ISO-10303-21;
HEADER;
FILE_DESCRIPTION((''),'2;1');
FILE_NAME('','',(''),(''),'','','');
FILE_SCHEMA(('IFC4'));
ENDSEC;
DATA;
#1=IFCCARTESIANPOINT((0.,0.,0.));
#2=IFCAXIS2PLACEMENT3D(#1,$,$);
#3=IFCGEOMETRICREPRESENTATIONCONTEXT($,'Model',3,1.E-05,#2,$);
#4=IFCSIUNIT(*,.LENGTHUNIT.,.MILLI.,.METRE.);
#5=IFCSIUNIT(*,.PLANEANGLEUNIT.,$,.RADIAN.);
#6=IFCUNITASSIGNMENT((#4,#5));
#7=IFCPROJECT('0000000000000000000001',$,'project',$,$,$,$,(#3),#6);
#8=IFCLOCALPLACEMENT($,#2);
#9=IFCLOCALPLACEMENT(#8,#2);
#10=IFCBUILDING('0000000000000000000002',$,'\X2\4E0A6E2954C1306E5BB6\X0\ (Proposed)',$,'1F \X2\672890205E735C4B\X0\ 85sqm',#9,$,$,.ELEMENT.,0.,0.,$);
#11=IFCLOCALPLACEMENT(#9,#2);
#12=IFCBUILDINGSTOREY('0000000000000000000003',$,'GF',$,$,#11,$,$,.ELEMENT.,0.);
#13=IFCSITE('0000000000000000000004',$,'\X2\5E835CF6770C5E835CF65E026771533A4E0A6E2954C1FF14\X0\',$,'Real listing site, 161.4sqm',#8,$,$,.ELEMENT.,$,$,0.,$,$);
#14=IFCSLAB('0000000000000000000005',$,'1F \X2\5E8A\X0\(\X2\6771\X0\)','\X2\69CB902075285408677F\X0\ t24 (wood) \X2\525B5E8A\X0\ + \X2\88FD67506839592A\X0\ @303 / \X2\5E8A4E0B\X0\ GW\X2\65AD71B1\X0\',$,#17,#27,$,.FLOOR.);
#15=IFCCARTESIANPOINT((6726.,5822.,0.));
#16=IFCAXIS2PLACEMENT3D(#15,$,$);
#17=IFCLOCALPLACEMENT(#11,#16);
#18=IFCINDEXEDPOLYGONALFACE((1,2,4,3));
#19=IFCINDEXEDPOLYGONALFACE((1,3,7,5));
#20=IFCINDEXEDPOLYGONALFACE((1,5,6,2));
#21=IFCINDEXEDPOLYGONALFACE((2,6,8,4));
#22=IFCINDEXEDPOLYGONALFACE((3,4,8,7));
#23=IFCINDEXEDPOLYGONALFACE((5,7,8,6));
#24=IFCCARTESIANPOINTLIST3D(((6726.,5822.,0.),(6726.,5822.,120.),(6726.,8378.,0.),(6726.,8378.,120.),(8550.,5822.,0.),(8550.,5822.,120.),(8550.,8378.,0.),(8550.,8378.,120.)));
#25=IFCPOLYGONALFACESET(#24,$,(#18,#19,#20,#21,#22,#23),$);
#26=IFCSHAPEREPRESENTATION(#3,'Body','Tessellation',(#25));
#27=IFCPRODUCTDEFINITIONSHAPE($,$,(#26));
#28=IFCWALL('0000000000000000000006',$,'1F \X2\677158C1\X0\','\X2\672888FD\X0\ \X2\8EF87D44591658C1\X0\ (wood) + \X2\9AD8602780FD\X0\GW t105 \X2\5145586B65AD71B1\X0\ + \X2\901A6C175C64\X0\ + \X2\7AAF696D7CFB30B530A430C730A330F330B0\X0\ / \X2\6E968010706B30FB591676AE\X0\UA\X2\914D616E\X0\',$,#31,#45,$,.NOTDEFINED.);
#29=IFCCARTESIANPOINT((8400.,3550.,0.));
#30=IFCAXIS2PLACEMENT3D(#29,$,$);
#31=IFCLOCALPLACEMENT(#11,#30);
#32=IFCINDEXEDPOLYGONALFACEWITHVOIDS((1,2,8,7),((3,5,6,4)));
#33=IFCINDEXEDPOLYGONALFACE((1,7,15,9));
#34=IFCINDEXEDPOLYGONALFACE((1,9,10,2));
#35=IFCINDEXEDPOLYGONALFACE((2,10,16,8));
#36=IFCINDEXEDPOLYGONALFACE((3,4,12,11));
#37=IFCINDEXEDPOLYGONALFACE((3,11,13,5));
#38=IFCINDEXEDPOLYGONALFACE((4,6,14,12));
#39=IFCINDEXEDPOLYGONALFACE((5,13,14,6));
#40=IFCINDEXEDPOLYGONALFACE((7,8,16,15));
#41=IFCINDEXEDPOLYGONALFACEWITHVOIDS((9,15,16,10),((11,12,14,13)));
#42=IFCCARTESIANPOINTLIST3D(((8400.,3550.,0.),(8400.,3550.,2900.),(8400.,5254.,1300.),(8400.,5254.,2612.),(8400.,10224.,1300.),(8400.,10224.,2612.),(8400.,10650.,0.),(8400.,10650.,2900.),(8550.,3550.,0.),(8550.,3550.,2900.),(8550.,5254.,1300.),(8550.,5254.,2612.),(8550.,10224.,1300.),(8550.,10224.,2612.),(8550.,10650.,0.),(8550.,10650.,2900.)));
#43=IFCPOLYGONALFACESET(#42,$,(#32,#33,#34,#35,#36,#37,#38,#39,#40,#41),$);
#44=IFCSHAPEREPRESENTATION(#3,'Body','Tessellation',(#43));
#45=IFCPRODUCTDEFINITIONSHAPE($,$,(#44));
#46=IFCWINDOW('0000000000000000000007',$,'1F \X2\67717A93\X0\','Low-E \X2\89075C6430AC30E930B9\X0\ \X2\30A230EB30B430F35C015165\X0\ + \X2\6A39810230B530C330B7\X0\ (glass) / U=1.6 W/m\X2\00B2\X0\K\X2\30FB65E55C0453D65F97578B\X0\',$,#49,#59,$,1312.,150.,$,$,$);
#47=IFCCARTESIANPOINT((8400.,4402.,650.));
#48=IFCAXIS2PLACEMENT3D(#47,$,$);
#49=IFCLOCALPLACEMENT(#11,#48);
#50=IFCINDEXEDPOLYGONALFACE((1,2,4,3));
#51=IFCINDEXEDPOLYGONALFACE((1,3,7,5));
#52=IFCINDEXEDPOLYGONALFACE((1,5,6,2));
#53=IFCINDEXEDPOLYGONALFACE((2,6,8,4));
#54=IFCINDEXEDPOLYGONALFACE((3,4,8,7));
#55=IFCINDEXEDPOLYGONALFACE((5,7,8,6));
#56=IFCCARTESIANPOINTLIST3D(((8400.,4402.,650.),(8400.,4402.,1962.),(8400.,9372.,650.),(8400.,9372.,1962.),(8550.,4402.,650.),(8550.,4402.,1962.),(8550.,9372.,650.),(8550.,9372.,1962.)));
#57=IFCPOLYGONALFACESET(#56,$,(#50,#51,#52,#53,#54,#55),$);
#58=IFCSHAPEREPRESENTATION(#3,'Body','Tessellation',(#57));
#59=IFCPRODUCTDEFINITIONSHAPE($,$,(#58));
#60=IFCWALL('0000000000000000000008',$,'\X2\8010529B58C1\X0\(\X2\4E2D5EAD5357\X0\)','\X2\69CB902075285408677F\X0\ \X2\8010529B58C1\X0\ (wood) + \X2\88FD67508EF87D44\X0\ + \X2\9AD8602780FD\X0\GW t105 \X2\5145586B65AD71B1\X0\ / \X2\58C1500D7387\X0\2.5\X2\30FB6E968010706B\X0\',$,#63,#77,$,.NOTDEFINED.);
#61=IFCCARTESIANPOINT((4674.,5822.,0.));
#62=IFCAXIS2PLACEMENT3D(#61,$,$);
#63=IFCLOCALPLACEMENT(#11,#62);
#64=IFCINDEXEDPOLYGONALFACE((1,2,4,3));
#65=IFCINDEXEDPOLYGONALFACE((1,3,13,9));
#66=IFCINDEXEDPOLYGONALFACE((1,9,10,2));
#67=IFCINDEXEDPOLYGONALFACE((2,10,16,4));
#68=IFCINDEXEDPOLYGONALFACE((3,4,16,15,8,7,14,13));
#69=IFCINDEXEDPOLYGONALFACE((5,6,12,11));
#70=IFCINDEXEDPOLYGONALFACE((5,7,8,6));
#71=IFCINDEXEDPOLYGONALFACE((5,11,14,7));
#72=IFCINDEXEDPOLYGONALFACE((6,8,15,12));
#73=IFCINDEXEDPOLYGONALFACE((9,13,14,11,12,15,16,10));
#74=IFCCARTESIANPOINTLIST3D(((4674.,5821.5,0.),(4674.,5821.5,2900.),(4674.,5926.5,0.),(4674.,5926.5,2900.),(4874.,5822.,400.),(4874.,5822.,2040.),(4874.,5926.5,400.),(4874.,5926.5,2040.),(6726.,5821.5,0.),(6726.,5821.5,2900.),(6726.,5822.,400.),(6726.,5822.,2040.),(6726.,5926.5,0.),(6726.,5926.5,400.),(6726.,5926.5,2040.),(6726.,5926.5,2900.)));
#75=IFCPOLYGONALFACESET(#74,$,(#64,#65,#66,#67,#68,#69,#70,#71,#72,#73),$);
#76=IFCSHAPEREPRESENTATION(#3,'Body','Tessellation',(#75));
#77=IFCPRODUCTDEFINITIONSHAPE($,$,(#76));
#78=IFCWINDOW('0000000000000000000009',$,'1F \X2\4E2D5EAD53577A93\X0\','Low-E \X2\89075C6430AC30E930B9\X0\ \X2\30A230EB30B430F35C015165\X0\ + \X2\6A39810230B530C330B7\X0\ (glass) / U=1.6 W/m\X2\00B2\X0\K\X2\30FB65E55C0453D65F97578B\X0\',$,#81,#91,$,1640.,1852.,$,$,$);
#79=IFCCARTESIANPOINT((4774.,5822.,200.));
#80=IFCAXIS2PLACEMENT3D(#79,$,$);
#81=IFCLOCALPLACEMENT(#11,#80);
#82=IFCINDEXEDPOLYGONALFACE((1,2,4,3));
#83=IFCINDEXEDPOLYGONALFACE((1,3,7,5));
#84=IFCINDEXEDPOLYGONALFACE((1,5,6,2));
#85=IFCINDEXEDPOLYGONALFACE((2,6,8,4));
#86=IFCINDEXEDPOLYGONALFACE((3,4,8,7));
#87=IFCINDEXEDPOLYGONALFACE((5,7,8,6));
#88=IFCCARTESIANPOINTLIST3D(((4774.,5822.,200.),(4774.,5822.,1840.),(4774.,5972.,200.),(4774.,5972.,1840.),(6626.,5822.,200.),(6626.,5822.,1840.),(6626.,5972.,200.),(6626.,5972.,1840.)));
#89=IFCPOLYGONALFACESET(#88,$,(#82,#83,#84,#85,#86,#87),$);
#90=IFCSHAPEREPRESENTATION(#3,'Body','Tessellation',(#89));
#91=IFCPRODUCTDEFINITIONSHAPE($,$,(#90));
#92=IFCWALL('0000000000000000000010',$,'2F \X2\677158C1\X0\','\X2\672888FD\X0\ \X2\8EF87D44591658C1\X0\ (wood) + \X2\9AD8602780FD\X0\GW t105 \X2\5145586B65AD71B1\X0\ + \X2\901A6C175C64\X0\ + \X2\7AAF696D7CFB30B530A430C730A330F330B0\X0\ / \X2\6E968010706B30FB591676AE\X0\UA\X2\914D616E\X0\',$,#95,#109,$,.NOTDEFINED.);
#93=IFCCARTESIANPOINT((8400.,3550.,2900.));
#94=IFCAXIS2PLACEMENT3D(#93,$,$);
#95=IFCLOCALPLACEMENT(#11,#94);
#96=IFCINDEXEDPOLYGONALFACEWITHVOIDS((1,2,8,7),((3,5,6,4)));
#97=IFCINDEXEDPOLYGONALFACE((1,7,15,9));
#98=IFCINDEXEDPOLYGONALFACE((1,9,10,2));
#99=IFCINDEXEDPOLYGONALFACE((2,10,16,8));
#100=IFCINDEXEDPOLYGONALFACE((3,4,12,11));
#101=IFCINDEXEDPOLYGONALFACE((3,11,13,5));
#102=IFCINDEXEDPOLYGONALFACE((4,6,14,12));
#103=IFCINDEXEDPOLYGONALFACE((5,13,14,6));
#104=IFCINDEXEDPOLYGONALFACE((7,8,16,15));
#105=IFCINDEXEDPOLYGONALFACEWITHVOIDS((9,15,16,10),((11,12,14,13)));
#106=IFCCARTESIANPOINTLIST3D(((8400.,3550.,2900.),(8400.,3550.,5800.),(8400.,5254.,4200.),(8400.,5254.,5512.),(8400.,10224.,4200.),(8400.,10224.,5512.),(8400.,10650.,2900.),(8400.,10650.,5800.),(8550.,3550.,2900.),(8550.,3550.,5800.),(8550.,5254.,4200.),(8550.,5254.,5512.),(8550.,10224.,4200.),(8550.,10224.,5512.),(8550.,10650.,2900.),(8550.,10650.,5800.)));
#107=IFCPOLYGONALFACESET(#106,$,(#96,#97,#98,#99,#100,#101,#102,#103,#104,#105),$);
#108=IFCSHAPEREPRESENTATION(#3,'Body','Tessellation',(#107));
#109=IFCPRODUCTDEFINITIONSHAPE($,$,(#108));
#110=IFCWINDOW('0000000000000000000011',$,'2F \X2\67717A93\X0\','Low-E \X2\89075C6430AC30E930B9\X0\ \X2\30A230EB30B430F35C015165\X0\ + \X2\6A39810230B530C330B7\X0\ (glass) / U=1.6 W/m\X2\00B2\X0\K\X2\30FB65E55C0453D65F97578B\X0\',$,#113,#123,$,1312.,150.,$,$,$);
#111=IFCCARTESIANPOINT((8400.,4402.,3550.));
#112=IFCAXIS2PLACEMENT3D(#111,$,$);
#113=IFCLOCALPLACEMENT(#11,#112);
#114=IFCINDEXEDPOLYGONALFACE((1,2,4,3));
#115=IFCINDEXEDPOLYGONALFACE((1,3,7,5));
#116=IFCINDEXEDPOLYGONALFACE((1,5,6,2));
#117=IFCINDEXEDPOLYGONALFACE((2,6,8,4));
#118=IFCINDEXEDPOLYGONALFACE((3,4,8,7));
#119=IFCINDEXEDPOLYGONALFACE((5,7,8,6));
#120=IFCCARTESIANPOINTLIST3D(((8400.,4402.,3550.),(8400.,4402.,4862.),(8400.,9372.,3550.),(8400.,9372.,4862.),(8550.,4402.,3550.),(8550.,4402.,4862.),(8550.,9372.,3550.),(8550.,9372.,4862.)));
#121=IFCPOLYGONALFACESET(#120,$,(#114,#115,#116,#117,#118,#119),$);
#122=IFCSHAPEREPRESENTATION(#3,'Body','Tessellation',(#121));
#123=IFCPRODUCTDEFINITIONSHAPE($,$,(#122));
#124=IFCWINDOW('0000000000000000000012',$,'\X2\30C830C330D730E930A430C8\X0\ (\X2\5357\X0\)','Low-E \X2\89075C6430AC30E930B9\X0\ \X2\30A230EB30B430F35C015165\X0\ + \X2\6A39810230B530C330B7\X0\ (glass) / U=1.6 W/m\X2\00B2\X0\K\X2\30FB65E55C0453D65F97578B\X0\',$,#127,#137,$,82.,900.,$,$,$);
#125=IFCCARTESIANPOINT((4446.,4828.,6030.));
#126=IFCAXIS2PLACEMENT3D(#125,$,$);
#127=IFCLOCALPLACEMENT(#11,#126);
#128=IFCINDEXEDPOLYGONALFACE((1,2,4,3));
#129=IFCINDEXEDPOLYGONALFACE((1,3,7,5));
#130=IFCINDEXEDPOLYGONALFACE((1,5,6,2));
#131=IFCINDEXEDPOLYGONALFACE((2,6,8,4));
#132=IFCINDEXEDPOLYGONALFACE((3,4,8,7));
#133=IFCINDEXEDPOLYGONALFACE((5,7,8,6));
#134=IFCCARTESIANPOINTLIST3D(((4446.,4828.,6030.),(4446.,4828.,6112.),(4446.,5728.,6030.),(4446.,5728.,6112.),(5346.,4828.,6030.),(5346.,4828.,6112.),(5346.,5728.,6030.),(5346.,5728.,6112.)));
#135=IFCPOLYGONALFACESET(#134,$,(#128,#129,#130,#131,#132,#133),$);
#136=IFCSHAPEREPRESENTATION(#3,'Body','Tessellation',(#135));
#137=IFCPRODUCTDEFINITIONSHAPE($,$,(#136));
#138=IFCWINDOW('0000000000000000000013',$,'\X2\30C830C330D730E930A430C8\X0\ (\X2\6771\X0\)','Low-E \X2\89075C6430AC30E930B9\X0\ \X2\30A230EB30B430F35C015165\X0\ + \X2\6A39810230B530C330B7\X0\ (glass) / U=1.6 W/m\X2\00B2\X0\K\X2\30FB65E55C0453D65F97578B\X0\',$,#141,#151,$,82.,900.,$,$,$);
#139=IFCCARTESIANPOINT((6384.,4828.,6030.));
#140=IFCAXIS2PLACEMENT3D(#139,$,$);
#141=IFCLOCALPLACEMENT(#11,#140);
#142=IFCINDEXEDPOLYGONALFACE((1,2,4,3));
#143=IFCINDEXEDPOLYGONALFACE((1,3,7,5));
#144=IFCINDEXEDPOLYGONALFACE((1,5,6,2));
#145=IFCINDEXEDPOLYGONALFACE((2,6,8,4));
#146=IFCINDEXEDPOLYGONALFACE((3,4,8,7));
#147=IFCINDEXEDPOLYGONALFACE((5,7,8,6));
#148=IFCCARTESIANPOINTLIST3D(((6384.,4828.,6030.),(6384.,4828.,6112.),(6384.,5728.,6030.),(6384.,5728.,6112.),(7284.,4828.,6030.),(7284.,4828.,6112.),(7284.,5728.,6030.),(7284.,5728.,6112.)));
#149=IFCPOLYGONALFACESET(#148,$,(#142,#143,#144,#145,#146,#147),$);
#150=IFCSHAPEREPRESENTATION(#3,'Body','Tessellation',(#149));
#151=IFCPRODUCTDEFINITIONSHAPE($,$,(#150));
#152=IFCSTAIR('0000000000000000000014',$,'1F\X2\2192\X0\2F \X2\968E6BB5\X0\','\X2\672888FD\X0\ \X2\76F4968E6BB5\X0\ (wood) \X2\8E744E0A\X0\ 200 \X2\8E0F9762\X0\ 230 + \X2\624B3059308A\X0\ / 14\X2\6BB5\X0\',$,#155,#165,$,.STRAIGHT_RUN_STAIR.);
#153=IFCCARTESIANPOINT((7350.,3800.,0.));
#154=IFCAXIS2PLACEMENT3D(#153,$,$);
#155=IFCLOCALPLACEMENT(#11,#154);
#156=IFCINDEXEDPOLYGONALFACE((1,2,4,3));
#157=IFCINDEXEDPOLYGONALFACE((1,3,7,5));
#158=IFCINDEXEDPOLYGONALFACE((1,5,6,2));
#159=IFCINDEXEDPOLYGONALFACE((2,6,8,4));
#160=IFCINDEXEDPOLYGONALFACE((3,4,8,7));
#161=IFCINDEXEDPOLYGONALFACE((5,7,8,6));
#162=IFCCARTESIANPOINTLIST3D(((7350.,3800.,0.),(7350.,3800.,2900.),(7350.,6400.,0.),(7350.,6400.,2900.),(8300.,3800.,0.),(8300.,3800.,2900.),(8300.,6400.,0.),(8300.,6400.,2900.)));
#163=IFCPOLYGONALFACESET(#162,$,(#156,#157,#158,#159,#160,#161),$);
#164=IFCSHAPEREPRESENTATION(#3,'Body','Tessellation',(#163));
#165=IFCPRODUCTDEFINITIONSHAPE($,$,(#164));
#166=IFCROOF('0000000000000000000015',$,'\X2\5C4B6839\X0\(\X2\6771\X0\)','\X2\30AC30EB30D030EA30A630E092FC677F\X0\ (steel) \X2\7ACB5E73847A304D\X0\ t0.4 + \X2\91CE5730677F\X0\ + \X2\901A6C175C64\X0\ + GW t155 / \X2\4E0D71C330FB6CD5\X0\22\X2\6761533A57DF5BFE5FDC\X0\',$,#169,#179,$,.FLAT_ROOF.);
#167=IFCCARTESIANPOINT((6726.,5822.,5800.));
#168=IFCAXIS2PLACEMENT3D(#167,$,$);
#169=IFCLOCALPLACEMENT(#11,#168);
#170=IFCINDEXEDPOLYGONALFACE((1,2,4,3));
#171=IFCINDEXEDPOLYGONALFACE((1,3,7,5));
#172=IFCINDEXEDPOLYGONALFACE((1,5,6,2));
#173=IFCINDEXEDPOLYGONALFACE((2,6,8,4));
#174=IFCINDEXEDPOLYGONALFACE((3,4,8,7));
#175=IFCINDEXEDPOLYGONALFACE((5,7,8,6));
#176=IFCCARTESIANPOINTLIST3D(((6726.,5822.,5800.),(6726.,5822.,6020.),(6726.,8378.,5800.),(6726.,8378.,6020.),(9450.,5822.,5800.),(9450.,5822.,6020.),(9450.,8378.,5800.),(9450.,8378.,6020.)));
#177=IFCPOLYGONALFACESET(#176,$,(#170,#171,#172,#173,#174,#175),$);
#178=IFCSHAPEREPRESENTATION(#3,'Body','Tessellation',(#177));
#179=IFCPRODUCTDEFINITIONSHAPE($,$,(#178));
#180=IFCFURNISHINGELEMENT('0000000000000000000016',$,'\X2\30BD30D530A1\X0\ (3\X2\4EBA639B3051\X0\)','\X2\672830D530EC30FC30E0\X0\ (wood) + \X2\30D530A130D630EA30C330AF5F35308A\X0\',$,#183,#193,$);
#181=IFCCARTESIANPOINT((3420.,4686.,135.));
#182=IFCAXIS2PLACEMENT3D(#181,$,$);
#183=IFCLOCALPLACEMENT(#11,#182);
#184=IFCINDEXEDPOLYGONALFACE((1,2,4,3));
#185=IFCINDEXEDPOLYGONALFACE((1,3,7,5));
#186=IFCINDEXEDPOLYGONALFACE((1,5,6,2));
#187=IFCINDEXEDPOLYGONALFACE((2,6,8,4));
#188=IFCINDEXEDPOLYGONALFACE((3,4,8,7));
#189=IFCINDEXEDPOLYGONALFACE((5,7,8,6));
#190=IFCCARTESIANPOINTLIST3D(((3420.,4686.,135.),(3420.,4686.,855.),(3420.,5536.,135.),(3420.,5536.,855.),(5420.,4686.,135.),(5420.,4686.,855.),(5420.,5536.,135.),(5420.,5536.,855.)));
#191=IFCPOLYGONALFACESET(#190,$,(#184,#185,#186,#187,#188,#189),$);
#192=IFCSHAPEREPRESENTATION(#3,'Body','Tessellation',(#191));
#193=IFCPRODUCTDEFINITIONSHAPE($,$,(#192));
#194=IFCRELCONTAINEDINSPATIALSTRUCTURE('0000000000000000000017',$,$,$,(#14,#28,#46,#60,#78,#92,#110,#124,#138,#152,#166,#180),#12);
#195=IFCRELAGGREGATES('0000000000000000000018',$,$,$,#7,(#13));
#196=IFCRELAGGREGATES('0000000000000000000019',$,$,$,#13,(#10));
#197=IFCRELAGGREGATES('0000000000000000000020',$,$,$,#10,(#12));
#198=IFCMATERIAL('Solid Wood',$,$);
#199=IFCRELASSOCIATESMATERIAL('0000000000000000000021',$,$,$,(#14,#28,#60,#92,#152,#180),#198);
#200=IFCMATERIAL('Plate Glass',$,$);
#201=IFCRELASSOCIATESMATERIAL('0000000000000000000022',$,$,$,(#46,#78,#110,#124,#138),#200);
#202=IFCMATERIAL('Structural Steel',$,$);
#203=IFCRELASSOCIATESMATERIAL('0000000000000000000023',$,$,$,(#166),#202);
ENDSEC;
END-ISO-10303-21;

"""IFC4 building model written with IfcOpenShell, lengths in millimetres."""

from ifc_helpers import new_model, si_unit, frame, frame_2d, origin, place, context, project, spatial, rectangle, extrude, material, element, fill, save


model = new_model("IFC4")

# Units and contexts
model_context = context("Model", 3, precision=1e-05, world=origin())
ifc_project = project(units=[si_unit("LENGTHUNIT", "METRE", prefix="MILLI"), si_unit("PLANEANGLEUNIT", "RADIAN")], contexts=[model_context])

# Site, building, storey
site_placement = place(None, origin())
site = spatial("IfcSite", under=ifc_project, at=site_placement, Name="広島県広島市東区上温品４", ObjectType="Real listing site, 161.4sqm", CompositionType="ELEMENT", RefElevation=0.0)
building_placement = place(site_placement, origin())
building = spatial("IfcBuilding", under=site, at=building_placement, Name="上温品の家 (Proposed)", ObjectType="1F 木造平屋 85sqm", CompositionType="ELEMENT", ElevationOfRefHeight=0.0, ElevationOfTerrain=0.0)
storey_placement = place(building_placement, origin())
storey = spatial("IfcBuildingStorey", under=building, at=storey_placement, Name="GF", CompositionType="ELEMENT", Elevation=0.0)

# Slab
ifc_material_1 = material(Name="Solid Wood")
slab_placement = place(storey_placement, frame((6726.0, 5822.0, 0.0)))
element("IfcSlab", 1, at=slab_placement, inside=storey, material=ifc_material_1, Name="1F 床(東)", Description="構造用合板 t24 (wood) 剛床 + 製材根太 @303 / 床下 GW断熱", PredefinedType="FLOOR", context=model_context, shape_type="SweptSolid", body=[
    extrude(rectangle(XDim=1824.0, YDim=2556.0, at=frame_2d((912.0, 1278.0))), frame((6726.0, 5822.0, 0.0)), (0.0, 0.0, 1.0), 120.0),
])

# Walls, openings, windows
wall_1_placement = place(storey_placement, frame((8400.0, 3550.0, 0.0)))
wall_1 = element("IfcWall", 2, at=wall_1_placement, inside=storey, material=ifc_material_1, Name="1F 東壁", Description="木製 軸組外壁 (wood) + 高性能GW t105 充填断熱 + 通気層 + 窯業系サイディング / 準耐火・外皮UA配慮", PredefinedType="NOTDEFINED", context=model_context, shape_type="SweptSolid", body=[
    extrude(rectangle(XDim=150.0, YDim=7100.0, at=frame_2d((75.0, 3550.0))), frame((8400.0, 3550.0, 0.0)), (0.0, 0.0, 1.0), 2900.0),
])
opening_1_placement = place(storey_placement, frame((8400.0, 4402.0, 650.0)))
opening_1 = element("IfcOpeningElement", 3, at=opening_1_placement, cuts=wall_1, PredefinedType="NOTDEFINED", context=model_context, shape_type="SweptSolid", body=[
    extrude(rectangle(XDim=150.0, YDim=4970.0, at=frame_2d((75.0, 2485.0))), frame((8400.0, 4402.0, 650.0)), (0.0, 0.0, 1.0), 1312.0),
])
ifc_material_2 = material(Name="Plate Glass")
window_1_placement = place(storey_placement, frame((8400.0, 4402.0, 650.0)))
window_1 = element("IfcWindow", 4, at=window_1_placement, inside=storey, material=ifc_material_2, Name="1F 東窓", Description="Low-E 複層ガラス アルゴン封入 + 樹脂サッシ (glass) / U=1.6 W/m²K・日射取得型", OverallHeight=1312.0, OverallWidth=150.0, context=model_context, shape_type="SweptSolid", body=[
    extrude(rectangle(XDim=150.0, YDim=4970.0, at=frame_2d((75.0, 2485.0))), frame((8400.0, 4402.0, 650.0)), (0.0, 0.0, 1.0), 1312.0),
])
fill(opening_1, window_1)
wall_2_placement = place(storey_placement, frame((4674.0, 5822.0, 0.0)))
wall_2 = element("IfcWall", 5, at=wall_2_placement, inside=storey, material=ifc_material_1, Name="耐力壁(中庭南)", Description="構造用合板 耐力壁 (wood) + 製材軸組 + 高性能GW t105 充填断熱 / 壁倍率2.5・準耐火", PredefinedType="NOTDEFINED", context=model_context, shape_type="SweptSolid", body=[
    extrude(rectangle(XDim=2052.0, YDim=105.0, at=frame_2d((1026.0, 52.0))), frame((4674.0, 5822.0, 0.0)), (0.0, 0.0, 1.0), 2900.0),
])
opening_2_placement = place(storey_placement, frame((4774.0, 5822.0, 200.0)))
opening_2 = element("IfcOpeningElement", 6, at=opening_2_placement, cuts=wall_2, PredefinedType="NOTDEFINED", context=model_context, shape_type="SweptSolid", body=[
    extrude(rectangle(XDim=1852.0, YDim=150.0, at=frame_2d((926.0, 75.0))), frame((4774.0, 5822.0, 200.0)), (0.0, 0.0, 1.0), 1640.0),
])
window_2_placement = place(storey_placement, frame((4774.0, 5822.0, 200.0)))
window_2 = element("IfcWindow", 7, at=window_2_placement, inside=storey, material=ifc_material_2, Name="1F 中庭南窓", Description="Low-E 複層ガラス アルゴン封入 + 樹脂サッシ (glass) / U=1.6 W/m²K・日射取得型", OverallHeight=1640.0, OverallWidth=1852.0, context=model_context, shape_type="SweptSolid", body=[
    extrude(rectangle(XDim=1852.0, YDim=150.0, at=frame_2d((926.0, 75.0))), frame((4774.0, 5822.0, 200.0)), (0.0, 0.0, 1.0), 1640.0),
])
fill(opening_2, window_2)

# Wall, opening, window
wall_3_placement = place(storey_placement, frame((8400.0, 3550.0, 2900.0)))
wall_3 = element("IfcWall", 8, at=wall_3_placement, inside=storey, material=ifc_material_1, Name="2F 東壁", Description="木製 軸組外壁 (wood) + 高性能GW t105 充填断熱 + 通気層 + 窯業系サイディング / 準耐火・外皮UA配慮", PredefinedType="NOTDEFINED", context=model_context, shape_type="SweptSolid", body=[
    extrude(rectangle(XDim=150.0, YDim=7100.0, at=frame_2d((75.0, 3550.0))), frame((8400.0, 3550.0, 2900.0)), (0.0, 0.0, 1.0), 2900.0),
])
opening_3_placement = place(storey_placement, frame((8400.0, 4402.0, 3550.0)))
opening_3 = element("IfcOpeningElement", 9, at=opening_3_placement, cuts=wall_3, PredefinedType="NOTDEFINED", context=model_context, shape_type="SweptSolid", body=[
    extrude(rectangle(XDim=150.0, YDim=4970.0, at=frame_2d((75.0, 2485.0))), frame((8400.0, 4402.0, 3550.0)), (0.0, 0.0, 1.0), 1312.0),
])
window_3_placement = place(storey_placement, frame((8400.0, 4402.0, 3550.0)))
window_3 = element("IfcWindow", 10, at=window_3_placement, inside=storey, material=ifc_material_2, Name="2F 東窓", Description="Low-E 複層ガラス アルゴン封入 + 樹脂サッシ (glass) / U=1.6 W/m²K・日射取得型", OverallHeight=1312.0, OverallWidth=150.0, context=model_context, shape_type="SweptSolid", body=[
    extrude(rectangle(XDim=150.0, YDim=4970.0, at=frame_2d((75.0, 2485.0))), frame((8400.0, 4402.0, 3550.0)), (0.0, 0.0, 1.0), 1312.0),
])
fill(opening_3, window_3)

# Windows
window_4_placement = place(storey_placement, frame((4446.0, 4828.0, 6030.0)))
element("IfcWindow", 11, at=window_4_placement, inside=storey, material=ifc_material_2, Name="トップライト (南)", Description="Low-E 複層ガラス アルゴン封入 + 樹脂サッシ (glass) / U=1.6 W/m²K・日射取得型", OverallHeight=82.0, OverallWidth=900.0, context=model_context, shape_type="SweptSolid", body=[
    extrude(rectangle(XDim=900.0, YDim=900.0, at=frame_2d((450.0, 450.0))), frame((4446.0, 4828.0, 6030.0)), (0.0, 0.0, 1.0), 82.0),
])
window_5_placement = place(storey_placement, frame((6384.0, 4828.0, 6030.0)))
element("IfcWindow", 12, at=window_5_placement, inside=storey, material=ifc_material_2, Name="トップライト (東)", Description="Low-E 複層ガラス アルゴン封入 + 樹脂サッシ (glass) / U=1.6 W/m²K・日射取得型", OverallHeight=82.0, OverallWidth=900.0, context=model_context, shape_type="SweptSolid", body=[
    extrude(rectangle(XDim=900.0, YDim=900.0, at=frame_2d((450.0, 450.0))), frame((6384.0, 4828.0, 6030.0)), (0.0, 0.0, 1.0), 82.0),
])

# Stair
stair_placement = place(storey_placement, frame((7350.0, 3800.0, 0.0)))
element("IfcStair", 13, at=stair_placement, inside=storey, material=ifc_material_1, Name="1F→2F 階段", Description="木製 直階段 (wood) 蹴上 200 踏面 230 + 手すり / 14段", PredefinedType="STRAIGHT_RUN_STAIR", context=model_context, shape_type="SweptSolid", body=[
    extrude(rectangle(XDim=950.0, YDim=2600.0, at=frame_2d((475.0, 1300.0))), frame((7350.0, 3800.0, 0.0)), (0.0, 0.0, 1.0), 2900.0),
])

# Roof
ifc_material_3 = material(Name="Structural Steel")
roof_placement = place(storey_placement, frame((6726.0, 5822.0, 5800.0)))
element("IfcRoof", 14, at=roof_placement, inside=storey, material=ifc_material_3, Name="屋根(東)", Description="ガルバリウム鋼板 (steel) 立平葺き t0.4 + 野地板 + 通気層 + GW t155 / 不燃・法22条区域対応", PredefinedType="FLAT_ROOF", context=model_context, shape_type="SweptSolid", body=[
    extrude(rectangle(XDim=2724.0, YDim=2556.0, at=frame_2d((1362.0, 1278.0))), frame((6726.0, 5822.0, 5800.0)), (0.0, 0.0, 1.0), 220.0),
])

# Furnishing element
furnishing_1_placement = place(storey_placement, frame((3420.0, 4686.0, 135.0)))
element("IfcFurnishingElement", 15, at=furnishing_1_placement, inside=storey, material=ifc_material_1, Name="ソファ (3人掛け)", Description="木フレーム (wood) + ファブリック張り", context=model_context, shape_type="SweptSolid", body=[
    extrude(rectangle(XDim=2000.0, YDim=850.0, at=frame_2d((1000.0, 425.0))), frame((3420.0, 4686.0, 135.0)), (0.0, 0.0, 1.0), 720.0),
])

save(model, "model.ifc")
